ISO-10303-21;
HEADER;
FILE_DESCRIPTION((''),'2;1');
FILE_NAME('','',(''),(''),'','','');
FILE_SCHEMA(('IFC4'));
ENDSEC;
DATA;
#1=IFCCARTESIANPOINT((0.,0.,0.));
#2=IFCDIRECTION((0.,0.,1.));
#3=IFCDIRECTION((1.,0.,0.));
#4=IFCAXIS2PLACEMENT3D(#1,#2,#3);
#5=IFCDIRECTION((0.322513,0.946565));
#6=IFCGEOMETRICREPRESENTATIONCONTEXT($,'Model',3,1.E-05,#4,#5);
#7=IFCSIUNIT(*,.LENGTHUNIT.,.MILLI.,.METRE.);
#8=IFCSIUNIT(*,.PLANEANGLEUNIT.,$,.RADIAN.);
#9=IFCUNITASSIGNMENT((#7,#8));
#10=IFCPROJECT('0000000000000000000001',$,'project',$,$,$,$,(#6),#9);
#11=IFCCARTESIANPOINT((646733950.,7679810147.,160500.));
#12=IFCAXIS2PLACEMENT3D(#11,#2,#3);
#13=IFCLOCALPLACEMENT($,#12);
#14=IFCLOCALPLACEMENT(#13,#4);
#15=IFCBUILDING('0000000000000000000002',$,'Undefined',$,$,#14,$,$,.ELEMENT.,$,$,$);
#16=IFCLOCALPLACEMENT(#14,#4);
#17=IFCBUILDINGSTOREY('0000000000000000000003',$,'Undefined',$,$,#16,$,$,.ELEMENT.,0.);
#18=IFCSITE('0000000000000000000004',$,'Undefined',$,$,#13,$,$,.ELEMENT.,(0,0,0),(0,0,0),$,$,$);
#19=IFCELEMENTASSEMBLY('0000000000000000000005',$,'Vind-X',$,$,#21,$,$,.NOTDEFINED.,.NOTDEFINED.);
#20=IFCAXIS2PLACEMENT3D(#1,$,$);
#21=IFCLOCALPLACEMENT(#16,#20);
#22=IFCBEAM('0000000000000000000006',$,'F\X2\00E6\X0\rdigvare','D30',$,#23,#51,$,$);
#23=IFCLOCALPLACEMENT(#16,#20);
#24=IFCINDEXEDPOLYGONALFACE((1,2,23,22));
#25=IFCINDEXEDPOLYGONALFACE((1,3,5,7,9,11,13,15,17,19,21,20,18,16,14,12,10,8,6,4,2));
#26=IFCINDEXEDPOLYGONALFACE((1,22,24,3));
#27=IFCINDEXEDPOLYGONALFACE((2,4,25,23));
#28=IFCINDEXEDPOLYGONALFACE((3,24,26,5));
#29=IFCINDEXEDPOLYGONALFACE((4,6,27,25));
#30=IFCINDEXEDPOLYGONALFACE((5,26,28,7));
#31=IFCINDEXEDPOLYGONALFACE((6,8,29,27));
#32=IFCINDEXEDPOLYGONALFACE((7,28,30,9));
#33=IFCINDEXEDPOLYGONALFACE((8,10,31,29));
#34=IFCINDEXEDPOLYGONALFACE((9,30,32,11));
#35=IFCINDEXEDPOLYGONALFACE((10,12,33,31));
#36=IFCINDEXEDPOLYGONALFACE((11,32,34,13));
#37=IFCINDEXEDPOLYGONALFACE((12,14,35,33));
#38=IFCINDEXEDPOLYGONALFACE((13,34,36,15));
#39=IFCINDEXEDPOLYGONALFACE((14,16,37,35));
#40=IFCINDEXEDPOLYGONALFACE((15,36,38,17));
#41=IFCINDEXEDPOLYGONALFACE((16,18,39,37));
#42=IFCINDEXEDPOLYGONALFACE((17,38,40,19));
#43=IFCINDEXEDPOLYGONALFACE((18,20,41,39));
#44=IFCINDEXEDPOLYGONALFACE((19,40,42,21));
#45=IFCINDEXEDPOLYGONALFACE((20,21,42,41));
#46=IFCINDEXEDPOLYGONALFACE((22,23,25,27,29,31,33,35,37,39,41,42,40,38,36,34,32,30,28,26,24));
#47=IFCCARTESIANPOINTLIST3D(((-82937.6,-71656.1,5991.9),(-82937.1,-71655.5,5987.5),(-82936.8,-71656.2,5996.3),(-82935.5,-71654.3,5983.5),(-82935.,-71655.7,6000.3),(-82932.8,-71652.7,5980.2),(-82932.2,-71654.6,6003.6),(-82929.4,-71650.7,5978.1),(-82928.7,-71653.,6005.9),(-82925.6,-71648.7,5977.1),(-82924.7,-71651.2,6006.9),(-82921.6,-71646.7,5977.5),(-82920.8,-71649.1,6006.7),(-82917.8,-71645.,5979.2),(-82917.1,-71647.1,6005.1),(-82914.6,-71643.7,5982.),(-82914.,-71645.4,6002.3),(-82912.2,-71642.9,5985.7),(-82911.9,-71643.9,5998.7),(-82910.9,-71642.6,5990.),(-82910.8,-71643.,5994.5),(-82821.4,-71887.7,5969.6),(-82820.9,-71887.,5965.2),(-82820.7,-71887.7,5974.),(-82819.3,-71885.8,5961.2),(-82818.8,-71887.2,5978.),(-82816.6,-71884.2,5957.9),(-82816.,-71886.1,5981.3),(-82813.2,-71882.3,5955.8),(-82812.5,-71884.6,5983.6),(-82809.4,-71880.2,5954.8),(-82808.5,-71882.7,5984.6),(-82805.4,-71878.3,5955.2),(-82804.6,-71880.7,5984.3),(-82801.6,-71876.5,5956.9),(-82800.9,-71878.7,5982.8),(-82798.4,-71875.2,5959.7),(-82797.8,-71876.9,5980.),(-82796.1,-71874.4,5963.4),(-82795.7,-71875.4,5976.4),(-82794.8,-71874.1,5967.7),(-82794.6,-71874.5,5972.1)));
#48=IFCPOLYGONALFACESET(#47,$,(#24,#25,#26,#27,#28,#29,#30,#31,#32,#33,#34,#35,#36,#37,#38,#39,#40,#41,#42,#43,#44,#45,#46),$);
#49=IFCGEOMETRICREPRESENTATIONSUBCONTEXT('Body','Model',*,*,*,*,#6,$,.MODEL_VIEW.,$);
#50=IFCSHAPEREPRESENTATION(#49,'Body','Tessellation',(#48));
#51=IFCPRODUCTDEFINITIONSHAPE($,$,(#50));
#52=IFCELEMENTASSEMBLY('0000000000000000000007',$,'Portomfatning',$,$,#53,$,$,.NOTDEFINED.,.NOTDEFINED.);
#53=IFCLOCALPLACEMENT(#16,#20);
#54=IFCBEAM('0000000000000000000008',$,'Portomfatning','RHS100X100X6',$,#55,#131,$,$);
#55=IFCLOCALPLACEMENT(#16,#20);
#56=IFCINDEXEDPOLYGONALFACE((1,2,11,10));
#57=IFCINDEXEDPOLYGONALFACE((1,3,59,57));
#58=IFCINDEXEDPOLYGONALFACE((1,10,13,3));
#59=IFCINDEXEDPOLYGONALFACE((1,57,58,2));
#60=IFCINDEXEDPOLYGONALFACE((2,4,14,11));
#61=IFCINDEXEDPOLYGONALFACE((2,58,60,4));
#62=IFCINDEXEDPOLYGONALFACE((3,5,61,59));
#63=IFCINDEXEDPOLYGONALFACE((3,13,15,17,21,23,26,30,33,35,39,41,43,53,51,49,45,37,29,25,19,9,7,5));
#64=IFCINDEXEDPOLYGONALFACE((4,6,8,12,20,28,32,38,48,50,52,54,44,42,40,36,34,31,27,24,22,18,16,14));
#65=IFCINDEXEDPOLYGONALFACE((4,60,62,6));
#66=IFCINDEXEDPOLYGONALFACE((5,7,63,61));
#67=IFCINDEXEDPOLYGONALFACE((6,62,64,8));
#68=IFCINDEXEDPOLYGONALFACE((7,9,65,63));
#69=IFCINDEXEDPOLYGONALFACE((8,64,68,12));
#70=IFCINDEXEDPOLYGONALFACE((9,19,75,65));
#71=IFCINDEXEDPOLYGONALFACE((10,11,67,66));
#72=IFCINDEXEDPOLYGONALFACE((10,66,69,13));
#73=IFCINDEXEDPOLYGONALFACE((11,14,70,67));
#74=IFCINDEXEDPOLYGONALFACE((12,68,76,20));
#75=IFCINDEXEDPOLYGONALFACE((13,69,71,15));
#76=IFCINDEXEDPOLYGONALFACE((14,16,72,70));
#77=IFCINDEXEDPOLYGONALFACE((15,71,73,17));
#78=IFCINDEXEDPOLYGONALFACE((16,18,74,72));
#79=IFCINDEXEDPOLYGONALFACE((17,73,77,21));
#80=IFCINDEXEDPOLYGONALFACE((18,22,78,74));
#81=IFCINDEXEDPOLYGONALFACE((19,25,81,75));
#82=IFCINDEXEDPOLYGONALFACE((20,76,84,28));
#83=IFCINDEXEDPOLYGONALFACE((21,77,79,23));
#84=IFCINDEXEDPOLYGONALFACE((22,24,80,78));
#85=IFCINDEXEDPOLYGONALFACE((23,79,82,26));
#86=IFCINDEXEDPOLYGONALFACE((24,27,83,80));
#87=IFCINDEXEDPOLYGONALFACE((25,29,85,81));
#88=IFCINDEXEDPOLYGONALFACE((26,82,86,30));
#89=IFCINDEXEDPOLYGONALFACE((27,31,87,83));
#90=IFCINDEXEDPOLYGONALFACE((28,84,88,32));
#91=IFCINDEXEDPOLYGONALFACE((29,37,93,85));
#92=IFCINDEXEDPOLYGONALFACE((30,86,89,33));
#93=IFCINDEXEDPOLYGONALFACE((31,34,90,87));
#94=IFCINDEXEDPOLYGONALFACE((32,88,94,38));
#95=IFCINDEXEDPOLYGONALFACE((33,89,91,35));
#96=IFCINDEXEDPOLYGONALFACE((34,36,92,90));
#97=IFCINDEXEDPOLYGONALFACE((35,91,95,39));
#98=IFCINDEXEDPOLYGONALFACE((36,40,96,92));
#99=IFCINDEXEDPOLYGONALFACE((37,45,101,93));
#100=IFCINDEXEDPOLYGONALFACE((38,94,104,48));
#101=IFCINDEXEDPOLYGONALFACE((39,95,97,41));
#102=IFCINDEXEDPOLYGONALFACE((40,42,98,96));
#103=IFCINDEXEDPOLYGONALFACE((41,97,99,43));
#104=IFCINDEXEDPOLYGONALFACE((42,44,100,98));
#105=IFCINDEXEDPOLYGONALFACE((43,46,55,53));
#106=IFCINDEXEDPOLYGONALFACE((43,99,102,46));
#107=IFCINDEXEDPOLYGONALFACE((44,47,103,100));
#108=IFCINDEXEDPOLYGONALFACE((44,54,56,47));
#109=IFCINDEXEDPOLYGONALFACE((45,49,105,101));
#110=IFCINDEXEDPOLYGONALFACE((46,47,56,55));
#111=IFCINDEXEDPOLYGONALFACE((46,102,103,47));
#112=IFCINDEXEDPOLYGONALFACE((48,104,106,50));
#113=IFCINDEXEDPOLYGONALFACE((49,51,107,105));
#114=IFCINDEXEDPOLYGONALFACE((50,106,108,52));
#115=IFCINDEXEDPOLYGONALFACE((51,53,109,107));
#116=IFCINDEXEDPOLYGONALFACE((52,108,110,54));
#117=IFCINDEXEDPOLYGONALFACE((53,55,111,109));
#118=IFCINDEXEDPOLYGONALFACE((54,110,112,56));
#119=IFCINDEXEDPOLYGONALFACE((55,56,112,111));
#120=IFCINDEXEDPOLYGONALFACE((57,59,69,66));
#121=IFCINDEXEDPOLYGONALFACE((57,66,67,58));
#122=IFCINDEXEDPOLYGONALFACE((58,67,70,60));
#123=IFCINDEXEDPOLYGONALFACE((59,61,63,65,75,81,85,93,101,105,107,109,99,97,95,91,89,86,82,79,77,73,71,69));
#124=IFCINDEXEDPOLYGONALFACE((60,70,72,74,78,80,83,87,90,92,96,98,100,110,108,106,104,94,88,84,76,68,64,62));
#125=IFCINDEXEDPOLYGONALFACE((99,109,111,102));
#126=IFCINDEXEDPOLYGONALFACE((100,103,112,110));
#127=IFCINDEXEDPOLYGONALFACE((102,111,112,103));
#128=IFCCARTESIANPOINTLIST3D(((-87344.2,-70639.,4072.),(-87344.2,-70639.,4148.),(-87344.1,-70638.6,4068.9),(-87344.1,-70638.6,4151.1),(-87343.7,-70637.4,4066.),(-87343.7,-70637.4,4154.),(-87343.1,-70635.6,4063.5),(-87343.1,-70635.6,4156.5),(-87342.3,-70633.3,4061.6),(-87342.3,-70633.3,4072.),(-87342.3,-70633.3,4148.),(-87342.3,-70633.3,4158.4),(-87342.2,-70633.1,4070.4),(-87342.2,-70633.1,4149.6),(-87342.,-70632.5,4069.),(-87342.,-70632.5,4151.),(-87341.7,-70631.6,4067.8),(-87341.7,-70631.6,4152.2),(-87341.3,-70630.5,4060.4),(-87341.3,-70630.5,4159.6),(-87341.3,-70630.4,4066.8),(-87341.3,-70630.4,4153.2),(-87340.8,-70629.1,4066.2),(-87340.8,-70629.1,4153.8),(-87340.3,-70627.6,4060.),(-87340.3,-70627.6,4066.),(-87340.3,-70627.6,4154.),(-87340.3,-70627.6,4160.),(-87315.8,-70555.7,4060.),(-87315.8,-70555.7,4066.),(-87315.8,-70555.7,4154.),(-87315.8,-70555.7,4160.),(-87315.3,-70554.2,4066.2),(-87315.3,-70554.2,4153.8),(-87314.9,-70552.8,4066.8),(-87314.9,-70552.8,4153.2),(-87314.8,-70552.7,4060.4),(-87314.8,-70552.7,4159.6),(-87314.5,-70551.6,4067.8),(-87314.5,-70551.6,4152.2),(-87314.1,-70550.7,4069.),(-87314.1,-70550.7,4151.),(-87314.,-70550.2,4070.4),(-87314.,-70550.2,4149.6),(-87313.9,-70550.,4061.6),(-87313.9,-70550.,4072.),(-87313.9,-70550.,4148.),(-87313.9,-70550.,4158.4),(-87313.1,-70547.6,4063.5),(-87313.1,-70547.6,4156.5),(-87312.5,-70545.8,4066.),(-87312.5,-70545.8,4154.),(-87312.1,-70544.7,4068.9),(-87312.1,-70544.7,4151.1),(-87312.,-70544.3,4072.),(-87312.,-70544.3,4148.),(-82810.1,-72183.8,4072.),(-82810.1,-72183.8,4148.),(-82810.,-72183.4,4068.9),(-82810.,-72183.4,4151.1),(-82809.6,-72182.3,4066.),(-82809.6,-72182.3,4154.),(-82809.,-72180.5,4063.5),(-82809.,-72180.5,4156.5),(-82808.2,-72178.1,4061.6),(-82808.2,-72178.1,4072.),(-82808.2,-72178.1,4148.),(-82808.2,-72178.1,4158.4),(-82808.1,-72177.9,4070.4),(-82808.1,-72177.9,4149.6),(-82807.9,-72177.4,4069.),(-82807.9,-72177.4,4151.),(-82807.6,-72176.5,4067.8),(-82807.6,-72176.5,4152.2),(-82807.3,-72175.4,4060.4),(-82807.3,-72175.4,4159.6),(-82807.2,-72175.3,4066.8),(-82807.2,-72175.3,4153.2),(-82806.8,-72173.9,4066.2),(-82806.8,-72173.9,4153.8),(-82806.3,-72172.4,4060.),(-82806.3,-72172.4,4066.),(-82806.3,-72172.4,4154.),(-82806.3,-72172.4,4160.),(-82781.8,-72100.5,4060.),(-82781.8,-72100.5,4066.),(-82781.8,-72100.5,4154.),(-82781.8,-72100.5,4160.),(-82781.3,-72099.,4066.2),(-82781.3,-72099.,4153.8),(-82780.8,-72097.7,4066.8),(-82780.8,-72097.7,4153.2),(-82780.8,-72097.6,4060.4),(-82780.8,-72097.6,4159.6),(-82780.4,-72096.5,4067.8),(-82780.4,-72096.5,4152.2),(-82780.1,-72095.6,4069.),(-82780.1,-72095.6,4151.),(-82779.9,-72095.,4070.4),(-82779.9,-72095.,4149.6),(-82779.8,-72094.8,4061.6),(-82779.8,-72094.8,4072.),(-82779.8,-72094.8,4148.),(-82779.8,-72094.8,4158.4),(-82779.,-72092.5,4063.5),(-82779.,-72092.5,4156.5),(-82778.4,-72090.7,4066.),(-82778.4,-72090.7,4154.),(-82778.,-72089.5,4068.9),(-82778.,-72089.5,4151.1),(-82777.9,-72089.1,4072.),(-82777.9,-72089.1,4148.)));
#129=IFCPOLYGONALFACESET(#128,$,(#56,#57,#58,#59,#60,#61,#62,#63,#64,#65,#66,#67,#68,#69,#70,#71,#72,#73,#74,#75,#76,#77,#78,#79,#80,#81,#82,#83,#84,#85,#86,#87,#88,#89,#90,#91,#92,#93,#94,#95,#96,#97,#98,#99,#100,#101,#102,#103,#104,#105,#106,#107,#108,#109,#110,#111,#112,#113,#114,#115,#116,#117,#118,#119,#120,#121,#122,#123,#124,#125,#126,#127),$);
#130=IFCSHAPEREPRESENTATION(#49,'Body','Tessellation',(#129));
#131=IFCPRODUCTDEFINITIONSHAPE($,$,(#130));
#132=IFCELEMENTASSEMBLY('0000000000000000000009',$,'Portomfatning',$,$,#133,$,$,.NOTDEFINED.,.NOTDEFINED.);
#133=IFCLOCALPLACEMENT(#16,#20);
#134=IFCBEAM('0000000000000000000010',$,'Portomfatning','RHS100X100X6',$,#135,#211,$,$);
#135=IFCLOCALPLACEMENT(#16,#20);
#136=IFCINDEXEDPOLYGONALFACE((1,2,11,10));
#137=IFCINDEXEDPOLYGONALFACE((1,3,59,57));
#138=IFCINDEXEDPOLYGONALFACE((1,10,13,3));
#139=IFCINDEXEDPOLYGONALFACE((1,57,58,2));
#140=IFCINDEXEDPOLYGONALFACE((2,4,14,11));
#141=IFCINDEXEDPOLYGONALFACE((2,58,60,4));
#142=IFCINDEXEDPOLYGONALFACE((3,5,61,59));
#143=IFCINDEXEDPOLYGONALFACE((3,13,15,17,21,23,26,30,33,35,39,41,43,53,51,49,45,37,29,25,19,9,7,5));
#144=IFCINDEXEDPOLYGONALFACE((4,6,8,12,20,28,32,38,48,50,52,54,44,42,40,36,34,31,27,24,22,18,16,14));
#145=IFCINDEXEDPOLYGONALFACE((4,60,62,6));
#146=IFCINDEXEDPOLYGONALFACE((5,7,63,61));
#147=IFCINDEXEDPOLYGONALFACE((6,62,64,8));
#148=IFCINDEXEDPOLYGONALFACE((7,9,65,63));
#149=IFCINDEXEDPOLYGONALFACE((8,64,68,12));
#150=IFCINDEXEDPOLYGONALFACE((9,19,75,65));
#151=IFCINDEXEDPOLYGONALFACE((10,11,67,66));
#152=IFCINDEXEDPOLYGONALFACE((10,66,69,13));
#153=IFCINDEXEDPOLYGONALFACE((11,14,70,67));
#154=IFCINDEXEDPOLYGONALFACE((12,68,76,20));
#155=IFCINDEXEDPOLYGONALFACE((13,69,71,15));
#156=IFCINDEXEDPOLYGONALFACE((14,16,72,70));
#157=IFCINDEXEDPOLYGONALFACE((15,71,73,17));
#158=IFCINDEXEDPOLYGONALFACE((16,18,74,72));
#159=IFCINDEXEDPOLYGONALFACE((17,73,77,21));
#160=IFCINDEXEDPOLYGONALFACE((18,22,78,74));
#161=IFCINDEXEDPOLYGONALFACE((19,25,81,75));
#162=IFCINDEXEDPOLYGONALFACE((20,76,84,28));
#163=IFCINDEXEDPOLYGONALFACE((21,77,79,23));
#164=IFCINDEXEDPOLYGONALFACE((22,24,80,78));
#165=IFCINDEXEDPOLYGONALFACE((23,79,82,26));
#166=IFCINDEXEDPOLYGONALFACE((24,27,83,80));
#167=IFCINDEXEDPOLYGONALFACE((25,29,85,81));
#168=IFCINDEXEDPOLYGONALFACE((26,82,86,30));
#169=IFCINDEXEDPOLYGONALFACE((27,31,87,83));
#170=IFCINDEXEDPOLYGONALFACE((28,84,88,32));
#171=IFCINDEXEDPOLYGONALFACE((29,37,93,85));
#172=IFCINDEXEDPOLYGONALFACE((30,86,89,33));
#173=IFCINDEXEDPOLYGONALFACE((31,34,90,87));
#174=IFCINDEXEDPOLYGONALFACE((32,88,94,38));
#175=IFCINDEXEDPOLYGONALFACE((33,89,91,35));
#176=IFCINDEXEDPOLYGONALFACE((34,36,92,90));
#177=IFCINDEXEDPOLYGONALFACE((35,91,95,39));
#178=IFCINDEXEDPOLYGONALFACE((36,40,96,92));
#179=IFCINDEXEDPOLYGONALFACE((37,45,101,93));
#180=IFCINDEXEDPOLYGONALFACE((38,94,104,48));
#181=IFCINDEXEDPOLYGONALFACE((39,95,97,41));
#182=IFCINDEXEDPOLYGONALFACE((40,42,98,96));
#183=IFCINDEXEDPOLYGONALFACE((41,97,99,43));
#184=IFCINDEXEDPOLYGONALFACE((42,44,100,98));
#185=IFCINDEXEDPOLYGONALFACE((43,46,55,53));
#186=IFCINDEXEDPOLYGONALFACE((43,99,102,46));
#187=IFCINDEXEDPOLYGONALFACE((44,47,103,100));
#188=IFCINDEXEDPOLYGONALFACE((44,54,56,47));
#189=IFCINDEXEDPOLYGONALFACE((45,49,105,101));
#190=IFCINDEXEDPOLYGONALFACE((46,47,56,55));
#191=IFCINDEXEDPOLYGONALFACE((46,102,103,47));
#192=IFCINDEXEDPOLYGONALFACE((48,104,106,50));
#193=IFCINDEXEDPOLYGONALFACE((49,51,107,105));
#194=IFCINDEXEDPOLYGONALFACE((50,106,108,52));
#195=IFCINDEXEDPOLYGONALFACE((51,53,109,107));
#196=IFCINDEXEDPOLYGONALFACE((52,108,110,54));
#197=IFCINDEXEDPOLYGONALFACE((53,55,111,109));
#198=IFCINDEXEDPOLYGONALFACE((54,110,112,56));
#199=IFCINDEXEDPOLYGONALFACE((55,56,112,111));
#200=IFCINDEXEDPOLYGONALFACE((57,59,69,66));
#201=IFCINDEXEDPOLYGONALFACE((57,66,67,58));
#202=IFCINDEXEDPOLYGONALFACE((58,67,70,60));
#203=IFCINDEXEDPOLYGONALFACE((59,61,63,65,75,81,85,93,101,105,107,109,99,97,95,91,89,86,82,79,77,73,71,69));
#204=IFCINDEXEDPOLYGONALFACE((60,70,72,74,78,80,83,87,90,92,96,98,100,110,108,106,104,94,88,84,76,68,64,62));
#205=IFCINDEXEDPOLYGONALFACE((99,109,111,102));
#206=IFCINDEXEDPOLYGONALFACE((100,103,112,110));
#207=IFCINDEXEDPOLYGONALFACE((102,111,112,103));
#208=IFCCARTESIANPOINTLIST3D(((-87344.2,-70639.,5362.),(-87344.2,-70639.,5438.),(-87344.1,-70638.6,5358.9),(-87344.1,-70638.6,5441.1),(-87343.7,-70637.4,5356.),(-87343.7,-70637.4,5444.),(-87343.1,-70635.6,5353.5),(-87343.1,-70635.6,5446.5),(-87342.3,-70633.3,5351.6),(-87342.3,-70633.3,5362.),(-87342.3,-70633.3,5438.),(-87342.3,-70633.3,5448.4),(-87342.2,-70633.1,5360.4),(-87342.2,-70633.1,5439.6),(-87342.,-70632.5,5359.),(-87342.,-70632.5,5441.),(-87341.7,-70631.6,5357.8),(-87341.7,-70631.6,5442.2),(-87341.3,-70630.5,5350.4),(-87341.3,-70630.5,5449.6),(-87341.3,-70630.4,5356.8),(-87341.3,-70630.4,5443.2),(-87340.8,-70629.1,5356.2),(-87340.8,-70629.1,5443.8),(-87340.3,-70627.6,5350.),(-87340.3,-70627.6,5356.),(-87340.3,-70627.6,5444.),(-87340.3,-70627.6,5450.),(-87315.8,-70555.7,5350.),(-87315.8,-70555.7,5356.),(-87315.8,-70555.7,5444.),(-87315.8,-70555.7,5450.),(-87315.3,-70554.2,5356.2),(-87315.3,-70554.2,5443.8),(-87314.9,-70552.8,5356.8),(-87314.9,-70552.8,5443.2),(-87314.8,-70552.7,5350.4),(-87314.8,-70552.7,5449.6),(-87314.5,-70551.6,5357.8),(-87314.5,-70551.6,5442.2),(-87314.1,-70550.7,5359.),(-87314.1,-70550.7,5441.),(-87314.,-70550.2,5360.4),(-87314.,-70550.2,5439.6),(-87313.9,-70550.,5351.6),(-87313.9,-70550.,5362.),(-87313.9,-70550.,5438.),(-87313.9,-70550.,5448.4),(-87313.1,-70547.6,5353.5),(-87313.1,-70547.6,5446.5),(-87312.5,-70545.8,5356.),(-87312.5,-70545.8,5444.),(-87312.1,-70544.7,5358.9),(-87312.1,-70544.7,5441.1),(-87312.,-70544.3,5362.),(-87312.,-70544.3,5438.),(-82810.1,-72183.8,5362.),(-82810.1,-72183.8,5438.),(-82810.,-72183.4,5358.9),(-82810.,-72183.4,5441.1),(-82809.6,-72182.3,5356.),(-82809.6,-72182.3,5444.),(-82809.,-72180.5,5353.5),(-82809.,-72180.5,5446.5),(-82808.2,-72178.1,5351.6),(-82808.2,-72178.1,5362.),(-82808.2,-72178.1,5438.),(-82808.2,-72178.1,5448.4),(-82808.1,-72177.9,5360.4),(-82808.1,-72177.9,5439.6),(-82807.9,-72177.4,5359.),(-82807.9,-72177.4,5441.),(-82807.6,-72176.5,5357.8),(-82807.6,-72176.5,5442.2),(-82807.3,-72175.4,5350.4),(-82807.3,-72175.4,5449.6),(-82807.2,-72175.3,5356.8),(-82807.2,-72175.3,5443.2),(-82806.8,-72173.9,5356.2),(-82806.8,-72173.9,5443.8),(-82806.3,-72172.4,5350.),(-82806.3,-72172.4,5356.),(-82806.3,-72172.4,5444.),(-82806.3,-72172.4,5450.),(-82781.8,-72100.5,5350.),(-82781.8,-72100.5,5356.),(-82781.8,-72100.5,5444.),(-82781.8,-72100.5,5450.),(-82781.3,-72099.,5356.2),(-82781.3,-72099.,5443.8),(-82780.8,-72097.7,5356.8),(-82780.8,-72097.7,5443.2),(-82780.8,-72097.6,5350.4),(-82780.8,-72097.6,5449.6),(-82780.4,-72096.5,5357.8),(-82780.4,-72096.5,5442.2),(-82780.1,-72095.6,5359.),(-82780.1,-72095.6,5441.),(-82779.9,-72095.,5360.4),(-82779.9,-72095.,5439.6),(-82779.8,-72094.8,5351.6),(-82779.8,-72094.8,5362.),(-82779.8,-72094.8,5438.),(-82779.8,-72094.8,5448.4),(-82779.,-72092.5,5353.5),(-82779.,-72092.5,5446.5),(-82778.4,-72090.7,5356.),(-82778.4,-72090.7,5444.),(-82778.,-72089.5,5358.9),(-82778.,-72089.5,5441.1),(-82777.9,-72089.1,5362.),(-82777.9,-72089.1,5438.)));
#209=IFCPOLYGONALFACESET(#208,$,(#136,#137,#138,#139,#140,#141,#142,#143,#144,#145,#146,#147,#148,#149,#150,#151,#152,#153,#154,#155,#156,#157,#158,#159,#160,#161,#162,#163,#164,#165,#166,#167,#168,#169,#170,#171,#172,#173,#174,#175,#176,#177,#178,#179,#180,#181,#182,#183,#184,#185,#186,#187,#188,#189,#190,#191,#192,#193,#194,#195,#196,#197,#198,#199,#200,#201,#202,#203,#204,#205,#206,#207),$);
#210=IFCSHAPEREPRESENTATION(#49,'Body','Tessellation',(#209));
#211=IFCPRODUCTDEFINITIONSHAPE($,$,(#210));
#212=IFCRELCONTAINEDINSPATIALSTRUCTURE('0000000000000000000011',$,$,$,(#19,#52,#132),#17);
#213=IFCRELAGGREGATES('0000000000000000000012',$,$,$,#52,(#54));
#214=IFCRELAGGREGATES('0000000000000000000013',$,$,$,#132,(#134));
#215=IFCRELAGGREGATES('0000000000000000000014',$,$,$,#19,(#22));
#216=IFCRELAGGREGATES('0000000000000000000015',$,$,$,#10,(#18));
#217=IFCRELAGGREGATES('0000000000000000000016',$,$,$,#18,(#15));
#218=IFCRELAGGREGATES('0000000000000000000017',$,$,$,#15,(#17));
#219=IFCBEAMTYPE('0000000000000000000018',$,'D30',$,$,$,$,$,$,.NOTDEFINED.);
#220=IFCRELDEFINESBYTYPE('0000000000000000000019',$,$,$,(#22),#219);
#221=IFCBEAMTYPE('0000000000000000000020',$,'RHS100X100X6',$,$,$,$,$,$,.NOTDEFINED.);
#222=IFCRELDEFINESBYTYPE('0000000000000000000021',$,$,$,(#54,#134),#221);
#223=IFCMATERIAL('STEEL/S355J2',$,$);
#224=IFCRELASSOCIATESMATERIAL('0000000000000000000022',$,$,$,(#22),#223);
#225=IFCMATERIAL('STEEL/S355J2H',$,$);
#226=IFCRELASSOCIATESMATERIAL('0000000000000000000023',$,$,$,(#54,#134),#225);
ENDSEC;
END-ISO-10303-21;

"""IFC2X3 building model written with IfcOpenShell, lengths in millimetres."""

from ifc_helpers import new_model, si_unit, direction, frame, origin_with_axes, origin_2d_with_axis, place, context, subcontext, project, spatial, hollow_rectangle, circle, extrude, clip, halfspace, material, type_object, element, aggregate, save


model = new_model("IFC2X3")

# Units and contexts
model_context = context("Model", 3, precision=1e-05, world=origin_with_axes(), true_north=direction((0.322513, 0.946565)))
body_context = subcontext(model_context, "Body", "Model", "MODEL_VIEW")
ifc_project = project(units=[si_unit("LENGTHUNIT", "METRE", prefix="MILLI"), si_unit("PLANEANGLEUNIT", "RADIAN")], contexts=[model_context])

# Site, building, storey
site_placement = place(None, frame((646733950.0, 7679810147.0, 160500.0), z_axis=(0.0, 0.0, 1.0), x_axis=(1.0, 0.0, 0.0)))
site = spatial("IfcSite", under=ifc_project, at=site_placement, Name="Undefined", CompositionType="ELEMENT", RefLatitude=(0, 0, 0), RefLongitude=(0, 0, 0))
building_placement = place(site_placement, origin_with_axes())
building = spatial("IfcBuilding", under=site, at=building_placement, Name="Undefined", CompositionType="ELEMENT")
storey_placement = place(building_placement, origin_with_axes())
storey = spatial("IfcBuildingStorey", under=building, at=storey_placement, Name="Undefined", CompositionType="ELEMENT", Elevation=0.0)

# Shared definitions
ifc_material_1 = material(Name="STEEL/S355J2H")

# Element assembly, beam
assembly_1_placement = place(storey_placement, origin_with_axes())
assembly_1 = element("IfcElementAssembly", 1, at=assembly_1_placement, inside=storey, Name="Vind-X", AssemblyPlace="NOTDEFINED", PredefinedType="NOTDEFINED")
ifc_material_2 = material(Name="STEEL/S355J2")
beam_type_1 = type_object("IfcBeamType", Name="D30", PredefinedType="NOTDEFINED")
beam_1_placement = place(assembly_1_placement, frame((-82808.0, -71881.0, 5969.7), z_axis=(-0.893742, -0.440152, -0.086548), x_axis=(-0.446855, 0.890482, 0.0858)))
beam_1 = element("IfcBeam", 2, at=beam_1_placement, type_object=beam_type_1, material=ifc_material_2, Name="Færdigvare", Description="D30", context=body_context, shape_type="SweptSolid", body=[
    extrude(circle(Radius=15.0, at=origin_2d_with_axis()), frame((260.0, 0.0, 0.0), z_axis=(-1.0, 0.0, 0.0), x_axis=(0.0, -1.0, 0.0)), (0.0, 0.0, 1.0), 260.0),
])

# Element assemblies, beams
assembly_2_placement = place(storey_placement, origin_with_axes())
assembly_2 = element("IfcElementAssembly", 3, at=assembly_2_placement, inside=storey, Name="Portomfatning", AssemblyPlace="NOTDEFINED", PredefinedType="NOTDEFINED")
beam_type_2 = type_object("IfcBeamType", Name="RHS100X100X6", PredefinedType="NOTDEFINED")
beam_2_placement = place(assembly_2_placement, frame((-82779.8, -72141.3, 4110.0), z_axis=(-0.322513, -0.946565, 0.0), x_axis=(-0.946565, 0.322513, 0.0)))
beam_2 = element("IfcBeam", 4, at=beam_2_placement, type_object=beam_type_2, material=ifc_material_1, Name="Portomfatning", Description="RHS100X100X6", context=body_context, shape_type="Clipping", body=[
    clip(clip(extrude(hollow_rectangle(XDim=100.0, YDim=100.0, WallThickness=6.0, InnerFilletRadius=6.0, OuterFilletRadius=12.0, at=origin_2d_with_axis()), frame((4866.7, 0.0, 0.0), z_axis=(-1.0, 0.0, 0.0), x_axis=(0.0, -1.0, 0.0)), (0.0, 0.0, 1.0), 4913.4), halfspace(frame((4805.0, -50.0, -50.0), z_axis=(-1.0, 0.0, 0.000185), x_axis=(0.0, 1.0, 0.0)), True)), halfspace(frame((15.0, 50.0, -50.0), z_axis=(1.0, 0.0, 0.000185), x_axis=(0.0, -1.0, 0.0)), True)),
])
assembly_3_placement = place(storey_placement, origin_with_axes())
assembly_3 = element("IfcElementAssembly", 5, at=assembly_3_placement, inside=storey, Name="Portomfatning", AssemblyPlace="NOTDEFINED", PredefinedType="NOTDEFINED")
beam_3_placement = place(assembly_3_placement, frame((-82779.8, -72141.3, 5400.0), z_axis=(-0.322513, -0.946565, 0.0), x_axis=(-0.946565, 0.322513, 0.0)))
beam_3 = element("IfcBeam", 6, at=beam_3_placement, type_object=beam_type_2, material=ifc_material_1, Name="Portomfatning", Description="RHS100X100X6", context=body_context, shape_type="Clipping", body=[
    clip(clip(extrude(hollow_rectangle(XDim=100.0, YDim=100.0, WallThickness=6.0, InnerFilletRadius=6.0, OuterFilletRadius=12.0, at=origin_2d_with_axis()), frame((4866.7, 0.0, 0.0), z_axis=(-1.0, 0.0, 0.0), x_axis=(0.0, -1.0, 0.0)), (0.0, 0.0, 1.0), 4913.4), halfspace(frame((4805.0, -50.0, -50.0), z_axis=(-1.0, 0.0, 0.000185), x_axis=(0.0, 1.0, 0.0)), True)), halfspace(frame((15.0, 50.0, -50.0), z_axis=(1.0, 0.0, 0.000185), x_axis=(0.0, -1.0, 0.0)), True)),
])

aggregate(assembly_2, [beam_2])
aggregate(assembly_3, [beam_3])

aggregate(assembly_1, [beam_1])

save(model, "model.ifc")
